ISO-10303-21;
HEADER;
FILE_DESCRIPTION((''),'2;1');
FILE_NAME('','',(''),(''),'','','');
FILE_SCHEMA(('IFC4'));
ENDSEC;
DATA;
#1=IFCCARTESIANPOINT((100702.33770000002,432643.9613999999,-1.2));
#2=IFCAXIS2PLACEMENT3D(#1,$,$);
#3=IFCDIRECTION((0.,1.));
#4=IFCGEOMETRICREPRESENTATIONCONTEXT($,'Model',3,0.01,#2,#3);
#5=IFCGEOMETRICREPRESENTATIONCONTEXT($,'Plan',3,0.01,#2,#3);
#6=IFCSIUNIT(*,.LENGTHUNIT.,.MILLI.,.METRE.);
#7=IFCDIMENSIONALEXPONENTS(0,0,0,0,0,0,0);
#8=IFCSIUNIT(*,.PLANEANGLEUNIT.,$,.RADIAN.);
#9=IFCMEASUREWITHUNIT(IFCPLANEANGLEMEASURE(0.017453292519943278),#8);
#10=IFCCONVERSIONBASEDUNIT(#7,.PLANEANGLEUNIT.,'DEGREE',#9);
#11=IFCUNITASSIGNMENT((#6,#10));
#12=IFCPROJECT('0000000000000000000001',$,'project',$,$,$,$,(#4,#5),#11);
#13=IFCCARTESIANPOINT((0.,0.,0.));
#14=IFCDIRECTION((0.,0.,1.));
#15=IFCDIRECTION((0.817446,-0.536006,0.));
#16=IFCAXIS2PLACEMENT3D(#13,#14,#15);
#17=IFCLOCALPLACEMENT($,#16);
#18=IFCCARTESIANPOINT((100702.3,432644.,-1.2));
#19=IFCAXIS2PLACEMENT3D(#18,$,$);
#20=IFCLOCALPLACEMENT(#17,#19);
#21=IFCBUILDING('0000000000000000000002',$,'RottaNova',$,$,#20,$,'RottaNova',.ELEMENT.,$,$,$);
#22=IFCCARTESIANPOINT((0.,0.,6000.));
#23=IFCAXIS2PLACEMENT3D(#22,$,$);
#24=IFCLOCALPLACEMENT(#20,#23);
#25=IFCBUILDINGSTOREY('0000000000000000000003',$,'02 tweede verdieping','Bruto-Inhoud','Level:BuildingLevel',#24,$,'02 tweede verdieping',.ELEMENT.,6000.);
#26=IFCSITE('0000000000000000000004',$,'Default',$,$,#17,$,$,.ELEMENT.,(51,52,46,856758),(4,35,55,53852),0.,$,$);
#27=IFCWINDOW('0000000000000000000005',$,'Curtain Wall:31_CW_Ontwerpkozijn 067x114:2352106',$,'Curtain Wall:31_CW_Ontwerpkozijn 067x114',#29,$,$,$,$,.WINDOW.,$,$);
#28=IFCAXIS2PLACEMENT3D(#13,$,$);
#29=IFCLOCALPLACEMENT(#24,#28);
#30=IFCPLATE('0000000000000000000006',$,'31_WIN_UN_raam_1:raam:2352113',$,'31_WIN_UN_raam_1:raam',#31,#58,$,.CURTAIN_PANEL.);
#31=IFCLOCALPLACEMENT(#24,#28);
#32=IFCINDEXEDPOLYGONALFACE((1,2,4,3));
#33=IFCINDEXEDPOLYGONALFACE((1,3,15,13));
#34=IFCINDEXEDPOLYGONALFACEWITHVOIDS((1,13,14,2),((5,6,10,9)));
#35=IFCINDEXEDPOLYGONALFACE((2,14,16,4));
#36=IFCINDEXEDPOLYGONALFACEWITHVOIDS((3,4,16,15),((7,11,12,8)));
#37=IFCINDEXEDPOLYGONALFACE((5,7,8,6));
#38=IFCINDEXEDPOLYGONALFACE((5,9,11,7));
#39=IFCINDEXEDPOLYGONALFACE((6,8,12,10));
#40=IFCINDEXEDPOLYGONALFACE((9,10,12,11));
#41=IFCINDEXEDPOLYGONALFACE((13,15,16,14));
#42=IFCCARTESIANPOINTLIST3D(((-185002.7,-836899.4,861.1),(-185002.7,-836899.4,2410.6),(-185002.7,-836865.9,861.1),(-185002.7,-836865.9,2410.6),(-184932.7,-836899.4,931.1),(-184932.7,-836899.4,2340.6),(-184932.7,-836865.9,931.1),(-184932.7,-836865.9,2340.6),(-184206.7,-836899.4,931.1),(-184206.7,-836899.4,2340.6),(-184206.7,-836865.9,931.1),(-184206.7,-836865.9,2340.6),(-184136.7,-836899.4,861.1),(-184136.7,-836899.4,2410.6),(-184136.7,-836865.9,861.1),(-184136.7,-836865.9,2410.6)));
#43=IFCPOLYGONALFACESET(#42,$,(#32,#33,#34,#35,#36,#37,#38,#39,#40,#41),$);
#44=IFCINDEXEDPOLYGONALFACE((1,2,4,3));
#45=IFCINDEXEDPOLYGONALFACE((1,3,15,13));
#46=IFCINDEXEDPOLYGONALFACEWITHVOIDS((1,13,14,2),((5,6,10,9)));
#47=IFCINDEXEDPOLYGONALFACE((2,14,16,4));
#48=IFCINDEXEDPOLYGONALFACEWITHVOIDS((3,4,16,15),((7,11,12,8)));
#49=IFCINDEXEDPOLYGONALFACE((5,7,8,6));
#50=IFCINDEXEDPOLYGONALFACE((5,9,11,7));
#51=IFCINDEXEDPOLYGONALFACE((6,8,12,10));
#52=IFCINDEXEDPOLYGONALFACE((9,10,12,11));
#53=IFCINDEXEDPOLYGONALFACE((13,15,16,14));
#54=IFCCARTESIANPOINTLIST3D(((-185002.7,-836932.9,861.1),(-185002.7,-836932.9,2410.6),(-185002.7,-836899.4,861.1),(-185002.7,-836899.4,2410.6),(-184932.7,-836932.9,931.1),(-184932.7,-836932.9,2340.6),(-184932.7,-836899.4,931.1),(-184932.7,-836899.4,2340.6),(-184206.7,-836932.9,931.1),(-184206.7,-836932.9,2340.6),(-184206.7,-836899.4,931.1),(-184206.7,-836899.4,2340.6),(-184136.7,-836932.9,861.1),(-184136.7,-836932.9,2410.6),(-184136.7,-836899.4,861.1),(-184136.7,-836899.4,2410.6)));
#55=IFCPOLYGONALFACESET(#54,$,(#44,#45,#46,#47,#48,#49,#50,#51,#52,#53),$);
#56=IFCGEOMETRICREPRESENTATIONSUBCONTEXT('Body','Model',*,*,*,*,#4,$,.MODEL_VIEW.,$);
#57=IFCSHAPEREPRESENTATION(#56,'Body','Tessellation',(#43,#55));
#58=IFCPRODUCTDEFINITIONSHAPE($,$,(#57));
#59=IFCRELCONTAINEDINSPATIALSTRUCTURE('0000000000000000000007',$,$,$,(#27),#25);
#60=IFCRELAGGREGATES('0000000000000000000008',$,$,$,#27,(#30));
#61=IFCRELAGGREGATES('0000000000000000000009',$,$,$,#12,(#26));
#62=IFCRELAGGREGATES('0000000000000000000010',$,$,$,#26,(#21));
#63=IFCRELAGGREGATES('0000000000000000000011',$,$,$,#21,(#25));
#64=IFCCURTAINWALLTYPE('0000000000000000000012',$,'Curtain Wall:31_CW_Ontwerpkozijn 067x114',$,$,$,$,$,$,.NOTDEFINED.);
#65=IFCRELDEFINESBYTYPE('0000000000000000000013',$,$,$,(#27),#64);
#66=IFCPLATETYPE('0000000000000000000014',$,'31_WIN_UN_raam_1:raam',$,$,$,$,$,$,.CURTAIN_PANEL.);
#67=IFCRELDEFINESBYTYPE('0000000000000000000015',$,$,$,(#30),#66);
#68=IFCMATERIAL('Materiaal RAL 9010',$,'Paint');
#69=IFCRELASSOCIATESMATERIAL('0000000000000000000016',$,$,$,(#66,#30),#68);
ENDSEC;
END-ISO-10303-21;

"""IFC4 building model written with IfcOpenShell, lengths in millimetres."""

from ifc_helpers import new_model, entity, si_unit, converted_unit, direction, frame, place, context, subcontext, project, spatial, indexed_curve, outline, extrude, source, transform, mapped, material, type_object, type_shapes, element, aggregate, save


model = new_model("IFC4")

# Units and contexts
model_context = context("Model", 3, precision=0.01, world=frame((100702.33770000002, 432643.9613999999, -1.2)), true_north=direction((0.0, 1.0)))
plan_context = context("Plan", 3, precision=0.01, world=frame((100702.33770000002, 432643.9613999999, -1.2)), true_north=direction((0.0, 1.0)))
body_context = subcontext(model_context, "Body", "Model", "MODEL_VIEW")
ifc_project = project(units=[si_unit("LENGTHUNIT", "METRE", prefix="MILLI"), converted_unit("PLANEANGLEUNIT", "DEGREE", entity("IfcPlaneAngleMeasure", 0.017453292519943278), si_unit("PLANEANGLEUNIT", "RADIAN"), dimensions=[0, 0, 0, 0, 0, 0, 0])], contexts=[model_context, plan_context])

# Site, building, storey
site_placement = place(None, frame((0.0, 0.0, 0.0), z_axis=(0.0, 0.0, 1.0), x_axis=(0.817446, -0.536006, 0.0)))
site = spatial("IfcSite", under=ifc_project, at=site_placement, Name="Default", CompositionType="ELEMENT", RefLatitude=(51, 52, 46, 856758), RefLongitude=(4, 35, 55, 53852), RefElevation=0.0)
building_placement = place(site_placement, frame((100702.3, 432644.0, -1.2)))
building = spatial("IfcBuilding", under=site, at=building_placement, Name="RottaNova", LongName="RottaNova", CompositionType="ELEMENT")
storey_placement = place(building_placement, frame((0.0, 0.0, 6000.0)))
storey = spatial("IfcBuildingStorey", under=building, at=storey_placement, Name="02 tweede verdieping", Description="Bruto-Inhoud", ObjectType="Level:BuildingLevel", LongName="02 tweede verdieping", CompositionType="ELEMENT", Elevation=6000.0)

# Window
curtain_wall_type = type_object("IfcCurtainWallType", Name="Curtain Wall:31_CW_Ontwerpkozijn 067x114", PredefinedType="NOTDEFINED")
window_1_placement = place(storey_placement, frame((0.0, 0.0, -6000.0)))
window_1 = element("IfcWindow", 1, at=window_1_placement, inside=storey, type_object=curtain_wall_type, Name="Curtain Wall:31_CW_Ontwerpkozijn 067x114:2352106", ObjectType="Curtain Wall:31_CW_Ontwerpkozijn 067x114", PredefinedType="WINDOW")

# Plate
ifc_material_1 = material(Name="Materiaal RAL 9010", Category="Paint")
plate_type_1 = type_object("IfcPlateType", Name="31_WIN_UN_raam_1:raam", PredefinedType="CURTAIN_PANEL", material=ifc_material_1)
shared_shape_1 = source(frame((100702.3, 432644.0, -1.2)), body_context, "Body", "SweptSolid", [
    extrude(outline(indexed_curve([(-433.0, -774.7), (433.0, -774.7), (433.0, 774.7), (-433.0, 774.7), (-433.0, -774.7)], self_intersect=False), holes=[indexed_curve([(-363.0, 704.7), (363.0, 704.7), (363.0, -704.8), (-363.0, -704.8), (-363.0, 704.7)], self_intersect=False)]), frame((0.0, -92.0, 774.8), z_axis=(0.0, 1.0, 0.0), x_axis=(1.0, 0.0, 0.0)), (0.0, 0.0, 1.0), 33.5),
    extrude(outline(indexed_curve([(-433.0, -774.7), (433.0, -774.7), (433.0, 774.7), (-433.0, 774.7), (-433.0, -774.7)], self_intersect=False), holes=[indexed_curve([(-363.0, 704.7), (363.0, 704.7), (363.0, -704.8), (-363.0, -704.8), (-363.0, 704.7)], self_intersect=False)]), frame((0.0, -58.5, 774.8), z_axis=(0.0, 1.0, 0.0), x_axis=(1.0, 0.0, 0.0)), (0.0, 0.0, 1.0), 33.5),
])
type_shapes(plate_type_1, [shared_shape_1])
plate_1_placement = place(window_1_placement, frame((16835.0, 28330.0, 6863.5), z_axis=(0.0, 0.0, 1.0), x_axis=(-1.0, 0.0, 0.0)))
plate_1 = element("IfcPlate", 2, at=plate_1_placement, type_object=plate_type_1, material=ifc_material_1, Name="31_WIN_UN_raam_1:raam:2352113", ObjectType="31_WIN_UN_raam_1:raam", PredefinedType="CURTAIN_PANEL", context=body_context, shape_type="MappedRepresentation", body=[
    mapped(shared_shape_1, transform((100702.3, 432644.0, -1.2), scale=1.0)),
])
aggregate(window_1, [plate_1])

save(model, "model.ifc")
